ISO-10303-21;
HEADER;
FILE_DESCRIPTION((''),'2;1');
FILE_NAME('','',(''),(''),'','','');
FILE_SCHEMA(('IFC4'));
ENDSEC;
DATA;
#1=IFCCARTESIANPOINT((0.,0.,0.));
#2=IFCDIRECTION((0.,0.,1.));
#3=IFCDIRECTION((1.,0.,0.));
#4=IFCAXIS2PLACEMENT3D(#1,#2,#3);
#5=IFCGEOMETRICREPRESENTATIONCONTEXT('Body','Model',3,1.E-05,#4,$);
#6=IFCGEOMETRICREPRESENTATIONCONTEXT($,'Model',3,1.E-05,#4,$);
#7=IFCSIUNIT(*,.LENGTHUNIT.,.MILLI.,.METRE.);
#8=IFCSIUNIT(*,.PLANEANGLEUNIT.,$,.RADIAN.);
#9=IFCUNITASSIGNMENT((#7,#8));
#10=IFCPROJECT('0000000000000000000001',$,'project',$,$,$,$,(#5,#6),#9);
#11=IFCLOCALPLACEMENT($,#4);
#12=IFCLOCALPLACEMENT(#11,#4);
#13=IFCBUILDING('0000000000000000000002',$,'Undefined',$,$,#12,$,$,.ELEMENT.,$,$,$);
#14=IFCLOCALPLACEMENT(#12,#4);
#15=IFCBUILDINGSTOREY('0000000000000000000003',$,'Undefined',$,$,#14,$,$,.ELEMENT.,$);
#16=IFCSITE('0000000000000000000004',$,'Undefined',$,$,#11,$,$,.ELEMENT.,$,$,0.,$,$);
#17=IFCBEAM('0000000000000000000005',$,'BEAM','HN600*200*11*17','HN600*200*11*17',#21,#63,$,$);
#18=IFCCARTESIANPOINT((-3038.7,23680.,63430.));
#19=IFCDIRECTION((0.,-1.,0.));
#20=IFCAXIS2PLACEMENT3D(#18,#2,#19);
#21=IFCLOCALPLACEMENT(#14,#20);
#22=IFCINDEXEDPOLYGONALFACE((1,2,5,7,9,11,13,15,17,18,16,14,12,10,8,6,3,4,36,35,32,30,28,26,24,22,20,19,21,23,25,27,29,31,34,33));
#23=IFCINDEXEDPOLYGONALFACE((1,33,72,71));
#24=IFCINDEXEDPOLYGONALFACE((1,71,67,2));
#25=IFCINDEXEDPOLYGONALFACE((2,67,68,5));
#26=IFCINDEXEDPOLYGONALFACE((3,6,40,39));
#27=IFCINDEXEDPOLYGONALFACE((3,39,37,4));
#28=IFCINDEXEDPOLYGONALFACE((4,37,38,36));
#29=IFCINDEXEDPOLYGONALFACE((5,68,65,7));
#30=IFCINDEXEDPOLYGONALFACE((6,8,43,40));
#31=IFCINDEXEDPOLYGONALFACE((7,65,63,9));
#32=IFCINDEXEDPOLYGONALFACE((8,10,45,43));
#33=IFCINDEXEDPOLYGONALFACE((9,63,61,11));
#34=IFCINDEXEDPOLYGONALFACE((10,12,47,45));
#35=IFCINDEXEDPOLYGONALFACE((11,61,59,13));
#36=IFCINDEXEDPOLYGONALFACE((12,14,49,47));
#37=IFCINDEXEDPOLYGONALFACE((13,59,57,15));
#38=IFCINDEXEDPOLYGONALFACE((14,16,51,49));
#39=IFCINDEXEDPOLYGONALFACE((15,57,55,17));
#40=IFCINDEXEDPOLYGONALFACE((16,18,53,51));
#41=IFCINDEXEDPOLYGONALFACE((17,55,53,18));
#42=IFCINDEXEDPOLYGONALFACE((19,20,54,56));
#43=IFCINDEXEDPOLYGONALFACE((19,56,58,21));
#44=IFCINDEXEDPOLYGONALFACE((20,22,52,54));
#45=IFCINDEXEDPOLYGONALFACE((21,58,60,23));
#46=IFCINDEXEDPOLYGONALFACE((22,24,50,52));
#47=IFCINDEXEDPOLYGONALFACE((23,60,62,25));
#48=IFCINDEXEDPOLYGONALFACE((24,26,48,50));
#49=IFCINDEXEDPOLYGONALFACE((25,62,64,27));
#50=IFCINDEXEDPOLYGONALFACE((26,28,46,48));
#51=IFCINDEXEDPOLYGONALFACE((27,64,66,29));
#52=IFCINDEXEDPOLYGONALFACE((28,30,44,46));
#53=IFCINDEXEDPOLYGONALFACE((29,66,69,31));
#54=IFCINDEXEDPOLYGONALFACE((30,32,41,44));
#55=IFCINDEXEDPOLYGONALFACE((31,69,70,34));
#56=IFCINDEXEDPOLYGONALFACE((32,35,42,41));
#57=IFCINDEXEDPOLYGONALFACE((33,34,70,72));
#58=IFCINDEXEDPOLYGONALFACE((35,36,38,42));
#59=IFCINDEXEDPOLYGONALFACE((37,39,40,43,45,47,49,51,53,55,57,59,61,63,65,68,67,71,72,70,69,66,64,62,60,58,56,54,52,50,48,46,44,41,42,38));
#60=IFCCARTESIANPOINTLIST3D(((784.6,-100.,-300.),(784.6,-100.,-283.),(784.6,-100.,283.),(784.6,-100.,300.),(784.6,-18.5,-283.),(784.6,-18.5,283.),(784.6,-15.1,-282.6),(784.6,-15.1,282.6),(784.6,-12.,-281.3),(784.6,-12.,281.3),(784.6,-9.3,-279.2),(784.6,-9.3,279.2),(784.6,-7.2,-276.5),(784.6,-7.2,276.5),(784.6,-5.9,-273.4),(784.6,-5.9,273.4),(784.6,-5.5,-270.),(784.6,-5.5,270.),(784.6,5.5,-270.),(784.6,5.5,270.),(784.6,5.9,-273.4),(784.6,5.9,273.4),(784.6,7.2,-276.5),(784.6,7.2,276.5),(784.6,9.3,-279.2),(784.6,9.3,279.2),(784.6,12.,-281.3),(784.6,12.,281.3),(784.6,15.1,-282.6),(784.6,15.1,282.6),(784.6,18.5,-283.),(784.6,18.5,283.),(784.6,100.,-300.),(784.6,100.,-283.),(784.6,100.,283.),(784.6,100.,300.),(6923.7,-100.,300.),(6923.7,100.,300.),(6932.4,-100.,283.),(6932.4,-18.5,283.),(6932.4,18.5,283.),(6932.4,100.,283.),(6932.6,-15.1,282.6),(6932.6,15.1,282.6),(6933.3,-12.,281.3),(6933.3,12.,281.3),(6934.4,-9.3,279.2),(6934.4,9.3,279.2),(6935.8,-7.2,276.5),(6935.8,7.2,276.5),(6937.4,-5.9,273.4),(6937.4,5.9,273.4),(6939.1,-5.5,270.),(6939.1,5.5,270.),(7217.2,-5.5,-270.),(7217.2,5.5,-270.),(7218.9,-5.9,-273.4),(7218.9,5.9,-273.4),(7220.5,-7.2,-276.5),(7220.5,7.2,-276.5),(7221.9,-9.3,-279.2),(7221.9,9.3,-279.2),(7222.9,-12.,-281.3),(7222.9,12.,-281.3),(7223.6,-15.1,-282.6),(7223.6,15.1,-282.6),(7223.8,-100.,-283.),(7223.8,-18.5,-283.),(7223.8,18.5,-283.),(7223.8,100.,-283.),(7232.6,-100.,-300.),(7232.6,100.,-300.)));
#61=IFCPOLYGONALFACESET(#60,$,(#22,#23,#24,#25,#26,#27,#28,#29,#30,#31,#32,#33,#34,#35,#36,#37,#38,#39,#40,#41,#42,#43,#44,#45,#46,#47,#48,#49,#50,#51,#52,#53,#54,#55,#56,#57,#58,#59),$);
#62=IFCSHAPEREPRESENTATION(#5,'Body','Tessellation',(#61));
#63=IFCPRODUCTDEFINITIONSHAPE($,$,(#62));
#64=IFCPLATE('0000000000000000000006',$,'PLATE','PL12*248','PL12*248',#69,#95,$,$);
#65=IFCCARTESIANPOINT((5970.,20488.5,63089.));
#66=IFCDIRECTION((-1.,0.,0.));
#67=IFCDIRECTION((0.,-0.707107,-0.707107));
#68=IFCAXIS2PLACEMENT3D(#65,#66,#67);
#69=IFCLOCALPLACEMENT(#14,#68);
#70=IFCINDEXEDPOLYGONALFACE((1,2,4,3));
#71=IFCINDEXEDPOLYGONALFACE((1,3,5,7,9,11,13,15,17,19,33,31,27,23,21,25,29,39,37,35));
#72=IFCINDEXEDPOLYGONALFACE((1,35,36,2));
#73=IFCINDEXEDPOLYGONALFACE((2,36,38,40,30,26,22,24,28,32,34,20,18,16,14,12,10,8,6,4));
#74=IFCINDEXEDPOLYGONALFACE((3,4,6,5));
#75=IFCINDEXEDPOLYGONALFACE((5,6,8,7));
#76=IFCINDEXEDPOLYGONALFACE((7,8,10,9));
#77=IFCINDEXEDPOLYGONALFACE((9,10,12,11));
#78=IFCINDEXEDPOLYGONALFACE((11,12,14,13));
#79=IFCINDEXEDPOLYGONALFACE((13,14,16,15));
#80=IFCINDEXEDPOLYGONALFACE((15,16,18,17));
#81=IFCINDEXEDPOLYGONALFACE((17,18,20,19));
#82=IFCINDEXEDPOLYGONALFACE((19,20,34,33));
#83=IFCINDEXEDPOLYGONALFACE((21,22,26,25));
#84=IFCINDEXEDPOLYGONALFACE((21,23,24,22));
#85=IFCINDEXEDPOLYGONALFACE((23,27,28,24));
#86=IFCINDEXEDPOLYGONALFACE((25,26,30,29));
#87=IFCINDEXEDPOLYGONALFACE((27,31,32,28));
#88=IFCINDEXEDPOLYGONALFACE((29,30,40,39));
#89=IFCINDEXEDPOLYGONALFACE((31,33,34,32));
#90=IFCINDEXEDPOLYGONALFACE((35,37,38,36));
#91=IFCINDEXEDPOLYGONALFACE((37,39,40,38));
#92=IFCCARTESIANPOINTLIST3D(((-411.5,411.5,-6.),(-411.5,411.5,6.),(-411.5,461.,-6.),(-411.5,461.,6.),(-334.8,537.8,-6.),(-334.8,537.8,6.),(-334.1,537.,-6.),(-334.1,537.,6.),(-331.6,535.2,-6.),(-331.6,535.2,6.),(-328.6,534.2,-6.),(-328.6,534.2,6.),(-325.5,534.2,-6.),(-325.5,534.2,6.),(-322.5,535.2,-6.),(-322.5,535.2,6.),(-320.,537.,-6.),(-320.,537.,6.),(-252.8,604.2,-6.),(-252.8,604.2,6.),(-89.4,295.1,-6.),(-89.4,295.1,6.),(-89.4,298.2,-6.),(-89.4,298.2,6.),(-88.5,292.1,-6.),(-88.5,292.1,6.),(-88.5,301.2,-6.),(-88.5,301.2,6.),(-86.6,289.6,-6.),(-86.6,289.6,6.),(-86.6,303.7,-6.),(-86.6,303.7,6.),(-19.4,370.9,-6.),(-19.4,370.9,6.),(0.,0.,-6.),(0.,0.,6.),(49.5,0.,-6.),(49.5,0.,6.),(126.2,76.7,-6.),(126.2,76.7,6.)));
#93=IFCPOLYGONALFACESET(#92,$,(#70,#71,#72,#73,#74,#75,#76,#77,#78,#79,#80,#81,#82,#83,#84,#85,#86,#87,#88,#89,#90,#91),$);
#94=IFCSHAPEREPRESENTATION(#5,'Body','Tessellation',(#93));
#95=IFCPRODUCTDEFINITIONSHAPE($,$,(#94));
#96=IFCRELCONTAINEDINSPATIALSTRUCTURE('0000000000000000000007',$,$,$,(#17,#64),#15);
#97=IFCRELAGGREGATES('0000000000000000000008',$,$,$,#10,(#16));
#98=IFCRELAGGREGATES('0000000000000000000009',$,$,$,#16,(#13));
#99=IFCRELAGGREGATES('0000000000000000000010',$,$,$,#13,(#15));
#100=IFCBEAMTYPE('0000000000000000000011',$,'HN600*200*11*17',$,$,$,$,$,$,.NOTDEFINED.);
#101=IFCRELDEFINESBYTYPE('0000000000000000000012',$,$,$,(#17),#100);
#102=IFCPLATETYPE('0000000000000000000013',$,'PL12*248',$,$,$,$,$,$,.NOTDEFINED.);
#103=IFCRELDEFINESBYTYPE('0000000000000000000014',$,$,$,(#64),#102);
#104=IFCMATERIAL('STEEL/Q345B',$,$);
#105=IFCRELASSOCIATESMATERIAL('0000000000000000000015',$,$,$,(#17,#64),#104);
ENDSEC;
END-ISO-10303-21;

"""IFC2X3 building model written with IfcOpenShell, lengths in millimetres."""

from ifc_helpers import new_model, si_unit, frame, origin_with_axes, origin_2d_with_axis, place, context, project, spatial, polyline, i_section, outline, extrude, clip, halfspace, material, type_object, element, save


model = new_model("IFC2X3")

# Units and contexts
model_context_1 = context("Model", 3, precision=1e-05, world=origin_with_axes(), identifier="Body")
model_context_2 = context("Model", 3, precision=1e-05, world=origin_with_axes())
ifc_project = project(units=[si_unit("LENGTHUNIT", "METRE", prefix="MILLI"), si_unit("PLANEANGLEUNIT", "RADIAN")], contexts=[model_context_1, model_context_2])

# Site, building, storey
site_placement = place(None, origin_with_axes())
site = spatial("IfcSite", under=ifc_project, at=site_placement, Name="Undefined", CompositionType="ELEMENT", RefElevation=0.0)
building_placement = place(site_placement, origin_with_axes())
building = spatial("IfcBuilding", under=site, at=building_placement, Name="Undefined", CompositionType="ELEMENT")
storey_placement = place(building_placement, origin_with_axes())
storey = spatial("IfcBuildingStorey", under=building, at=storey_placement, Name="Undefined", CompositionType="ELEMENT")

# Shared definitions
ifc_material_1 = material(Name="STEEL/Q345B")

# Beam
beam_type_1 = type_object("IfcBeamType", Name="HN600*200*11*17", PredefinedType="NOTDEFINED")
beam_1_placement = place(storey_placement, frame((-3038.7, 23680.0, 63430.0), z_axis=(0.0, 0.0, 1.0), x_axis=(0.0, -1.0, 0.0)))
element("IfcBeam", 1, at=beam_1_placement, inside=storey, type_object=beam_type_1, material=ifc_material_1, Name="BEAM", Description="HN600*200*11*17", ObjectType="HN600*200*11*17", context=model_context_1, shape_type="Clipping", body=[
    clip(clip(extrude(i_section(OverallWidth=200.0, OverallDepth=600.0, WebThickness=11.0, FlangeThickness=17.0, FilletRadius=13.0, at=origin_2d_with_axis()), frame((7234.1, 0.0, 0.0), z_axis=(-1.0, 0.0, 0.0), x_axis=(0.0, -1.0, 0.0)), (0.0, 0.0, 1.0), 6449.5), halfspace(frame((6923.7, 0.0, 300.0), z_axis=(-0.88907, 0.0, -0.457771), x_axis=(0.457771, 0.0, -0.88907)), True)), halfspace(frame((784.6, 0.0, 1000.0), z_axis=(-1.0, 0.0, 0.0), x_axis=(0.0, -1.0, 0.0)), False)),
])

# Plate
plate_type_1 = type_object("IfcPlateType", Name="PL12*248", PredefinedType="NOTDEFINED")
for number, where, z_axis, x_axis, name in (
    (2, (5970.0, 20488.5, 63089.0), (-1.0, 0.0, 0.0), (0.0, -0.707107, -0.707107), "PLATE"),
):
    element("IfcPlate", number, at=place(storey_placement, frame(where, z_axis=z_axis, x_axis=x_axis)), inside=storey, type_object=plate_type_1, material=ifc_material_1, Name=name, Description="PL12*248", ObjectType="PL12*248", context=model_context_1, shape_type="SweptSolid", body=[
        extrude(outline(polyline([(0.0, 0.0), (49.5, 0.0), (126.2, 76.7), (-86.6, 289.6), (-88.5, 292.1), (-89.4, 295.1), (-89.4, 298.2), (-88.5, 301.2), (-86.6, 303.7), (-19.4, 370.9), (-252.8, 604.2), (-320.0, 537.0), (-322.5, 535.2), (-325.5, 534.2), (-328.6, 534.2), (-331.6, 535.2), (-334.1, 537.0), (-334.8, 537.8), (-411.5, 461.0), (-411.5, 411.5), (0.0, 0.0)])), frame((0.0, 0.0, -6.0), z_axis=(0.0, 0.0, 1.0), x_axis=(1.0, 0.0, 0.0)), (0.0, 0.0, 1.0), 12.0),
    ])

save(model, "model.ifc")
